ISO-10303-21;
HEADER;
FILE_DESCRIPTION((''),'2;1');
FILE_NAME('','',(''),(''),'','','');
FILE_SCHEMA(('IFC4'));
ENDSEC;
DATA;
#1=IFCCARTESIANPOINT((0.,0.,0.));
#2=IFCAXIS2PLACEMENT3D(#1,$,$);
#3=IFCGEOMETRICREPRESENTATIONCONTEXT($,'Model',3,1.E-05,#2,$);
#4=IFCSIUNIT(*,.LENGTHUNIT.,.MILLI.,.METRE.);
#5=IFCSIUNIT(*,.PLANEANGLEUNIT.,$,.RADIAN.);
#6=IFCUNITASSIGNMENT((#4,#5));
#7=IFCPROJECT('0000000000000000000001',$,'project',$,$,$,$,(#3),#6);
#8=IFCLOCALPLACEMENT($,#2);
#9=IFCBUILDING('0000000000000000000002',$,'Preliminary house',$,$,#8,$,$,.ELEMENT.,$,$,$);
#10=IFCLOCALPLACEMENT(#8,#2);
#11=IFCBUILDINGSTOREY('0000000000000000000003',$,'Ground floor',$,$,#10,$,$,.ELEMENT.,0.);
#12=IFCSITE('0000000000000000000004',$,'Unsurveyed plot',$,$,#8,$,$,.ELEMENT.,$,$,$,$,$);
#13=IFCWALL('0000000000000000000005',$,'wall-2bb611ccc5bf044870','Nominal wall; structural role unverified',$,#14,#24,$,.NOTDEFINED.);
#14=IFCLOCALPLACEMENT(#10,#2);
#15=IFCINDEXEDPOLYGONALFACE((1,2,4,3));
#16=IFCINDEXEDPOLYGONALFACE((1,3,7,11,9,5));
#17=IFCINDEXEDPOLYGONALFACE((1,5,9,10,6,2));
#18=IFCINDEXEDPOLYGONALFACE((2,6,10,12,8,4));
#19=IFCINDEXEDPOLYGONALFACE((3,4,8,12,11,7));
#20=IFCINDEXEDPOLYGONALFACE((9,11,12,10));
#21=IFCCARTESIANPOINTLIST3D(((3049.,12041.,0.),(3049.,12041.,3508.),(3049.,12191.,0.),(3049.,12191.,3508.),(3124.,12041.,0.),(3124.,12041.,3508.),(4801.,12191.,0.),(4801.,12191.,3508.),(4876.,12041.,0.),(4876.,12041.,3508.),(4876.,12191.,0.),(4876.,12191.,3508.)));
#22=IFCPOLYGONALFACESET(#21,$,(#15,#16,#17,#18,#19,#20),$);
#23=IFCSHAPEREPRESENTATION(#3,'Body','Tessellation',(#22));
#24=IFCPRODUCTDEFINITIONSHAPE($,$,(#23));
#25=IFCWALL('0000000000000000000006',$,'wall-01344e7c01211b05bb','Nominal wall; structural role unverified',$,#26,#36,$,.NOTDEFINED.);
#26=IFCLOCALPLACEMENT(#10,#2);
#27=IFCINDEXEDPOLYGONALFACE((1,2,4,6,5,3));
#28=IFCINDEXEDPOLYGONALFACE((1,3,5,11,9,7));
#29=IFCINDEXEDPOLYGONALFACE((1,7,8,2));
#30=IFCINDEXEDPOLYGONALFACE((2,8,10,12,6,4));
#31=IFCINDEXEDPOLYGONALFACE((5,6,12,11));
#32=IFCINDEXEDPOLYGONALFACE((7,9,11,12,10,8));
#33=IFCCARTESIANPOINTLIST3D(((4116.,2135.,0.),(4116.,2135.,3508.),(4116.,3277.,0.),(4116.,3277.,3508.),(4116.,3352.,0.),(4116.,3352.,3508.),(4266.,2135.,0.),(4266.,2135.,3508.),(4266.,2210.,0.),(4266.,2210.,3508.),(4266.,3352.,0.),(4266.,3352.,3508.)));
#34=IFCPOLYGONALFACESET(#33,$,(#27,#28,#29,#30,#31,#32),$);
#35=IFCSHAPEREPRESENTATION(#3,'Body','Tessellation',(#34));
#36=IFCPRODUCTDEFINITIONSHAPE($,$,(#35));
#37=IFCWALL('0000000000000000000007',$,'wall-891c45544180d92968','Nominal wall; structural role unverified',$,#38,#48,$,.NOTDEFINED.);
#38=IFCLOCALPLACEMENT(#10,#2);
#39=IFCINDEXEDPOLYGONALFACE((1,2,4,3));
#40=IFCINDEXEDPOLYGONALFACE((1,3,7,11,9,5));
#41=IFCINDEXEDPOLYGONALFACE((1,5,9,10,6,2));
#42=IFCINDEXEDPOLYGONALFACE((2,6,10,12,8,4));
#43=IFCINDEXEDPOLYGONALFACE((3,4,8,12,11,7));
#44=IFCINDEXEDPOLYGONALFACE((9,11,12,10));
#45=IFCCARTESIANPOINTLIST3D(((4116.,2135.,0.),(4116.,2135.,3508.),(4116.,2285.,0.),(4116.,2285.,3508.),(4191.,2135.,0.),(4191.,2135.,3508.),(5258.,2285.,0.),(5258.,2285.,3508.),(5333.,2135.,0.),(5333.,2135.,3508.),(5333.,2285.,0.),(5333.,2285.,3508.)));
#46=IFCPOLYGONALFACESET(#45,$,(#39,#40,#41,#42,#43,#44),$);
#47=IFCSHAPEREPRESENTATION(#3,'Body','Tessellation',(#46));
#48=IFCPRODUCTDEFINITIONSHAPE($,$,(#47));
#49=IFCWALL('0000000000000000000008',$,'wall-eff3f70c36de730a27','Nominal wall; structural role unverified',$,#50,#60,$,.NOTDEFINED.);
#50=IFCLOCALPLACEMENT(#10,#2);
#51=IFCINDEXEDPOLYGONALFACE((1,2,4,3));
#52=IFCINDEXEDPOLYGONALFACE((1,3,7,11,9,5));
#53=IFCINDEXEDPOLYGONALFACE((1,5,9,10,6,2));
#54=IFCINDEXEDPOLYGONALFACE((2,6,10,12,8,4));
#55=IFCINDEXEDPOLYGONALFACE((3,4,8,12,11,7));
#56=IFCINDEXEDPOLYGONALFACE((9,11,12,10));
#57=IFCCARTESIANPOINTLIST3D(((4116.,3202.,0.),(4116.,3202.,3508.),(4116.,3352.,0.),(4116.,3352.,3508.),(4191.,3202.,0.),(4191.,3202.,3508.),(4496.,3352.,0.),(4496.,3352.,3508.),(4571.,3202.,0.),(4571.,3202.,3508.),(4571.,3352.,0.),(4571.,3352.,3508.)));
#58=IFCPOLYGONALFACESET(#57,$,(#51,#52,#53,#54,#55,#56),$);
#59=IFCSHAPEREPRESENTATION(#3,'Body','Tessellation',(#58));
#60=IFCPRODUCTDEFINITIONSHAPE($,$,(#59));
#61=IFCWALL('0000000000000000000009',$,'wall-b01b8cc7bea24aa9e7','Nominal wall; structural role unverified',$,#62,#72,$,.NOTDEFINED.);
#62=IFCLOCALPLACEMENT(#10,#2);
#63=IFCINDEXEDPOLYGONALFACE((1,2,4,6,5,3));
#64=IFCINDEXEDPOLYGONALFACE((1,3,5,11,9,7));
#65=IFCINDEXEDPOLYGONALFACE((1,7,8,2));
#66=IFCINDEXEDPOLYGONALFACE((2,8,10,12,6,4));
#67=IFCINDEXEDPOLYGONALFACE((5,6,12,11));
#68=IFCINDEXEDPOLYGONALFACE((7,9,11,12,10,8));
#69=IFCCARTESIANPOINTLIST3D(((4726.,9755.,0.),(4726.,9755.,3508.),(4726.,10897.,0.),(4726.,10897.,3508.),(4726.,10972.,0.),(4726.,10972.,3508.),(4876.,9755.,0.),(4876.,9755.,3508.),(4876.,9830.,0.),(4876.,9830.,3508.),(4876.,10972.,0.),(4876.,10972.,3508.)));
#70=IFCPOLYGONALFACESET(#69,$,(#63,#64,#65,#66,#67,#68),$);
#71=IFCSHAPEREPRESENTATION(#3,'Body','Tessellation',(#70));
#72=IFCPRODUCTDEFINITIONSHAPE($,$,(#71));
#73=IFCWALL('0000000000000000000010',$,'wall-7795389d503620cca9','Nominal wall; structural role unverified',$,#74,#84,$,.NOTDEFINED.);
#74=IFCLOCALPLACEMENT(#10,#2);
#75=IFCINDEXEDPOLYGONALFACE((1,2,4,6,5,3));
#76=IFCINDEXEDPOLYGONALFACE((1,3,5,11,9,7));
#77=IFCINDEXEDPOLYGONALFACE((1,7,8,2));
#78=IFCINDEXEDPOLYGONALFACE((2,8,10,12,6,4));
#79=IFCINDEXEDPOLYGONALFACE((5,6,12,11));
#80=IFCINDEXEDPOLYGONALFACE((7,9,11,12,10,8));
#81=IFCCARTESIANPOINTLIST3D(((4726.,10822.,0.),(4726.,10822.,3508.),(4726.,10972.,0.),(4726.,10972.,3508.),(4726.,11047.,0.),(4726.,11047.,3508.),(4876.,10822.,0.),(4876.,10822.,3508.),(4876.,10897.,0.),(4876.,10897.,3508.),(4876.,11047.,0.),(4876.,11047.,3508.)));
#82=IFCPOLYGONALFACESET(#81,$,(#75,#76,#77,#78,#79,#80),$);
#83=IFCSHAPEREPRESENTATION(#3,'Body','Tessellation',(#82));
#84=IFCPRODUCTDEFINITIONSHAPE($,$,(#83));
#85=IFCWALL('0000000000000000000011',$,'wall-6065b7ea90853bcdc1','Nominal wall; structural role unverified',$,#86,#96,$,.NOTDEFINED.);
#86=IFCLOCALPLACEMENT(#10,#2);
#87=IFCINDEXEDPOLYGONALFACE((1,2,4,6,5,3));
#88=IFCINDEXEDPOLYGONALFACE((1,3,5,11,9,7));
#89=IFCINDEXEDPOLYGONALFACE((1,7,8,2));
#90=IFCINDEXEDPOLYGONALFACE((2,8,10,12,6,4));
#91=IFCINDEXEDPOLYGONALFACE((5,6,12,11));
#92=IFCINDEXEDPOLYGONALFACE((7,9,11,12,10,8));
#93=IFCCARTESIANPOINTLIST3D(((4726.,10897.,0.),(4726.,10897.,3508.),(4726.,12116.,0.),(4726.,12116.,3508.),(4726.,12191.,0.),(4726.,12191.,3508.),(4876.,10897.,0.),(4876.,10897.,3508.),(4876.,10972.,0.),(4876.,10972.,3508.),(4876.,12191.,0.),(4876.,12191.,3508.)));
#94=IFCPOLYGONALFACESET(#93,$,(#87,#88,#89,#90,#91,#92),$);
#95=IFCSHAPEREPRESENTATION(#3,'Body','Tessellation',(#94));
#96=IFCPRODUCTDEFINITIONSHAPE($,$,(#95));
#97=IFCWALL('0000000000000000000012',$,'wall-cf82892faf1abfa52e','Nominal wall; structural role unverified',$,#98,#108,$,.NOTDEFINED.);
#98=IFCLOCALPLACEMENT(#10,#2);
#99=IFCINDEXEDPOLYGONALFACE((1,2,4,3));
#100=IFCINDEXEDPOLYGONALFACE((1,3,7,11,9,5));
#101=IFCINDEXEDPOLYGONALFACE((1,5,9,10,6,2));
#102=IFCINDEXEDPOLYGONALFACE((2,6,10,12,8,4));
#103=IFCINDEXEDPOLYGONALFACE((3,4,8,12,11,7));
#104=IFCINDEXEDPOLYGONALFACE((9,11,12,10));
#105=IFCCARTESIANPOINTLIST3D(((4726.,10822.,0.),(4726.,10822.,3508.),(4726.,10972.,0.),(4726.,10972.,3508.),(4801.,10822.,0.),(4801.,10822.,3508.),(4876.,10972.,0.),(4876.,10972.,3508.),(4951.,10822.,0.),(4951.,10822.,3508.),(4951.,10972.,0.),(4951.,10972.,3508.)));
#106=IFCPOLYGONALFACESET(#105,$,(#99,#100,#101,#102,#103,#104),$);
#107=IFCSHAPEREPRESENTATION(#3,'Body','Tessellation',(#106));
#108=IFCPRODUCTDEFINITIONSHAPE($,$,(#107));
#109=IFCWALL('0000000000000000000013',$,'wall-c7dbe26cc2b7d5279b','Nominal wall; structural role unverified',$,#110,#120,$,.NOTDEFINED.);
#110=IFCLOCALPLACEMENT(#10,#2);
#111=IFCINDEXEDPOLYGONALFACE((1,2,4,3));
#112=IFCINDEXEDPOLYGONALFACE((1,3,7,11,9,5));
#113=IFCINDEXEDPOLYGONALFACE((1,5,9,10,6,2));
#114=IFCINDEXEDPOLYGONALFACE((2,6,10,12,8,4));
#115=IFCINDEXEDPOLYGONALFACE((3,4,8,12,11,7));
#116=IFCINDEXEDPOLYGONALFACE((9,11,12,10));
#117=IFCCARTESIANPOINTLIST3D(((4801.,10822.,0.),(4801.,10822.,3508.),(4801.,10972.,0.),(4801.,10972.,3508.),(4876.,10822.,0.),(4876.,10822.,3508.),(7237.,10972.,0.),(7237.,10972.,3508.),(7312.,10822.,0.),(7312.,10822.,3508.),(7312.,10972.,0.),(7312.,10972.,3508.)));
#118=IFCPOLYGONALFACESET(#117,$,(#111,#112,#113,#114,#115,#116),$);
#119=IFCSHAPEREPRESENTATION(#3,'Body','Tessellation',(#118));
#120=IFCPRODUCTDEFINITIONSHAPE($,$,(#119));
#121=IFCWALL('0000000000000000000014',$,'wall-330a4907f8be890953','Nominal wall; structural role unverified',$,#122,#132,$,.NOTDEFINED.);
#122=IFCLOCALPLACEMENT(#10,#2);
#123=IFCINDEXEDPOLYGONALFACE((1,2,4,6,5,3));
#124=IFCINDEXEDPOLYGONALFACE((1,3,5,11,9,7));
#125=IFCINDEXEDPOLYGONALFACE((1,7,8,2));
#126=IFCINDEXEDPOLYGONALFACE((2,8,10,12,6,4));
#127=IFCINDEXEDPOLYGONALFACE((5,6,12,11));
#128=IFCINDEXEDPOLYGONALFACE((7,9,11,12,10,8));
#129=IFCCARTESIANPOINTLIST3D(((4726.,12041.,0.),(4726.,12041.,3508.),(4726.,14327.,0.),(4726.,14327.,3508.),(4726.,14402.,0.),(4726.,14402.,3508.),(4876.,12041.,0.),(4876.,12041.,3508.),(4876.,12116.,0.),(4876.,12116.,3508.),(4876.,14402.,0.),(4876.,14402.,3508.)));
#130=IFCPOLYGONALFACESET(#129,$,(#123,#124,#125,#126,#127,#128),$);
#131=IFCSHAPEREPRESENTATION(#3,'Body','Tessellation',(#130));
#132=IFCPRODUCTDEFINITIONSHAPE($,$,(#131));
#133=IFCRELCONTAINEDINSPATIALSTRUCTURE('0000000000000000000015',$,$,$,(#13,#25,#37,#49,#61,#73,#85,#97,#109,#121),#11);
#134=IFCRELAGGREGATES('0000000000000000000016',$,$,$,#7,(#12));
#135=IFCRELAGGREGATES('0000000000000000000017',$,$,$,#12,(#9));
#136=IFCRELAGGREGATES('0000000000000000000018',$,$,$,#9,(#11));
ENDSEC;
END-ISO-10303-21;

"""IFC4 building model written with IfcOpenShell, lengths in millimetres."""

from ifc_helpers import new_model, si_unit, origin, place, context, project, spatial, polyline, outline, extrude, element, save


model = new_model("IFC4")

# Units and contexts
model_context = context("Model", 3, precision=1e-05, world=origin())
ifc_project = project(units=[si_unit("LENGTHUNIT", "METRE", prefix="MILLI"), si_unit("PLANEANGLEUNIT", "RADIAN")], contexts=[model_context])

# Site, building, storey
placement_1 = place(None, origin())
site = spatial("IfcSite", under=ifc_project, at=placement_1, Name="Unsurveyed plot", CompositionType="ELEMENT")
building = spatial("IfcBuilding", under=site, at=placement_1, Name="Preliminary house", CompositionType="ELEMENT")
placement_2 = place(placement_1, origin())
storey = spatial("IfcBuildingStorey", under=building, at=placement_2, Name="Ground floor", CompositionType="ELEMENT", Elevation=0.0)

# Wall
element("IfcWall", 1, at=placement_2, inside=storey, Name="wall-2bb611ccc5bf044870", Description="Nominal wall; structural role unverified", PredefinedType="NOTDEFINED", context=model_context, shape_type="SweptSolid", body=[
    extrude(outline(polyline([(4801.0, 12191.0), (4876.0, 12191.0), (4876.0, 12041.0), (3124.0, 12041.0), (3049.0, 12041.0), (3049.0, 12191.0), (4801.0, 12191.0)])), origin(), (0.0, 0.0, 1.0), 3508.0),
])

# Walls
element("IfcWall", 2, at=placement_2, inside=storey, Name="wall-01344e7c01211b05bb", Description="Nominal wall; structural role unverified", PredefinedType="NOTDEFINED", context=model_context, shape_type="SweptSolid", body=[
    extrude(outline(polyline([(4116.0, 3277.0), (4116.0, 3352.0), (4266.0, 3352.0), (4266.0, 2210.0), (4266.0, 2135.0), (4116.0, 2135.0), (4116.0, 3277.0)])), origin(), (0.0, 0.0, 1.0), 3508.0),
])
element("IfcWall", 3, at=placement_2, inside=storey, Name="wall-891c45544180d92968", Description="Nominal wall; structural role unverified", PredefinedType="NOTDEFINED", context=model_context, shape_type="SweptSolid", body=[
    extrude(outline(polyline([(5258.0, 2285.0), (5333.0, 2285.0), (5333.0, 2135.0), (4191.0, 2135.0), (4116.0, 2135.0), (4116.0, 2285.0), (5258.0, 2285.0)])), origin(), (0.0, 0.0, 1.0), 3508.0),
])
element("IfcWall", 4, at=placement_2, inside=storey, Name="wall-eff3f70c36de730a27", Description="Nominal wall; structural role unverified", PredefinedType="NOTDEFINED", context=model_context, shape_type="SweptSolid", body=[
    extrude(outline(polyline([(4496.0, 3352.0), (4571.0, 3352.0), (4571.0, 3202.0), (4191.0, 3202.0), (4116.0, 3202.0), (4116.0, 3352.0), (4496.0, 3352.0)])), origin(), (0.0, 0.0, 1.0), 3508.0),
])

# Wall
element("IfcWall", 5, at=placement_2, inside=storey, Name="wall-b01b8cc7bea24aa9e7", Description="Nominal wall; structural role unverified", PredefinedType="NOTDEFINED", context=model_context, shape_type="SweptSolid", body=[
    extrude(outline(polyline([(4726.0, 10897.0), (4726.0, 10972.0), (4876.0, 10972.0), (4876.0, 9830.0), (4876.0, 9755.0), (4726.0, 9755.0), (4726.0, 10897.0)])), origin(), (0.0, 0.0, 1.0), 3508.0),
])

# Walls
element("IfcWall", 6, at=placement_2, inside=storey, Name="wall-7795389d503620cca9", Description="Nominal wall; structural role unverified", PredefinedType="NOTDEFINED", context=model_context, shape_type="SweptSolid", body=[
    extrude(outline(polyline([(4726.0, 10972.0), (4726.0, 11047.0), (4876.0, 11047.0), (4876.0, 10897.0), (4876.0, 10822.0), (4726.0, 10822.0), (4726.0, 10972.0)])), origin(), (0.0, 0.0, 1.0), 3508.0),
])
element("IfcWall", 7, at=placement_2, inside=storey, Name="wall-6065b7ea90853bcdc1", Description="Nominal wall; structural role unverified", PredefinedType="NOTDEFINED", context=model_context, shape_type="SweptSolid", body=[
    extrude(outline(polyline([(4726.0, 12116.0), (4726.0, 12191.0), (4876.0, 12191.0), (4876.0, 10972.0), (4876.0, 10897.0), (4726.0, 10897.0), (4726.0, 12116.0)])), origin(), (0.0, 0.0, 1.0), 3508.0),
])
element("IfcWall", 8, at=placement_2, inside=storey, Name="wall-cf82892faf1abfa52e", Description="Nominal wall; structural role unverified", PredefinedType="NOTDEFINED", context=model_context, shape_type="SweptSolid", body=[
    extrude(outline(polyline([(4876.0, 10972.0), (4951.0, 10972.0), (4951.0, 10822.0), (4801.0, 10822.0), (4726.0, 10822.0), (4726.0, 10972.0), (4876.0, 10972.0)])), origin(), (0.0, 0.0, 1.0), 3508.0),
])
element("IfcWall", 9, at=placement_2, inside=storey, Name="wall-c7dbe26cc2b7d5279b", Description="Nominal wall; structural role unverified", PredefinedType="NOTDEFINED", context=model_context, shape_type="SweptSolid", body=[
    extrude(outline(polyline([(7237.0, 10972.0), (7312.0, 10972.0), (7312.0, 10822.0), (4876.0, 10822.0), (4801.0, 10822.0), (4801.0, 10972.0), (7237.0, 10972.0)])), origin(), (0.0, 0.0, 1.0), 3508.0),
])
element("IfcWall", 10, at=placement_2, inside=storey, Name="wall-330a4907f8be890953", Description="Nominal wall; structural role unverified", PredefinedType="NOTDEFINED", context=model_context, shape_type="SweptSolid", body=[
    extrude(outline(polyline([(4726.0, 14327.0), (4726.0, 14402.0), (4876.0, 14402.0), (4876.0, 12116.0), (4876.0, 12041.0), (4726.0, 12041.0), (4726.0, 14327.0)])), origin(), (0.0, 0.0, 1.0), 3508.0),
])

save(model, "model.ifc")
